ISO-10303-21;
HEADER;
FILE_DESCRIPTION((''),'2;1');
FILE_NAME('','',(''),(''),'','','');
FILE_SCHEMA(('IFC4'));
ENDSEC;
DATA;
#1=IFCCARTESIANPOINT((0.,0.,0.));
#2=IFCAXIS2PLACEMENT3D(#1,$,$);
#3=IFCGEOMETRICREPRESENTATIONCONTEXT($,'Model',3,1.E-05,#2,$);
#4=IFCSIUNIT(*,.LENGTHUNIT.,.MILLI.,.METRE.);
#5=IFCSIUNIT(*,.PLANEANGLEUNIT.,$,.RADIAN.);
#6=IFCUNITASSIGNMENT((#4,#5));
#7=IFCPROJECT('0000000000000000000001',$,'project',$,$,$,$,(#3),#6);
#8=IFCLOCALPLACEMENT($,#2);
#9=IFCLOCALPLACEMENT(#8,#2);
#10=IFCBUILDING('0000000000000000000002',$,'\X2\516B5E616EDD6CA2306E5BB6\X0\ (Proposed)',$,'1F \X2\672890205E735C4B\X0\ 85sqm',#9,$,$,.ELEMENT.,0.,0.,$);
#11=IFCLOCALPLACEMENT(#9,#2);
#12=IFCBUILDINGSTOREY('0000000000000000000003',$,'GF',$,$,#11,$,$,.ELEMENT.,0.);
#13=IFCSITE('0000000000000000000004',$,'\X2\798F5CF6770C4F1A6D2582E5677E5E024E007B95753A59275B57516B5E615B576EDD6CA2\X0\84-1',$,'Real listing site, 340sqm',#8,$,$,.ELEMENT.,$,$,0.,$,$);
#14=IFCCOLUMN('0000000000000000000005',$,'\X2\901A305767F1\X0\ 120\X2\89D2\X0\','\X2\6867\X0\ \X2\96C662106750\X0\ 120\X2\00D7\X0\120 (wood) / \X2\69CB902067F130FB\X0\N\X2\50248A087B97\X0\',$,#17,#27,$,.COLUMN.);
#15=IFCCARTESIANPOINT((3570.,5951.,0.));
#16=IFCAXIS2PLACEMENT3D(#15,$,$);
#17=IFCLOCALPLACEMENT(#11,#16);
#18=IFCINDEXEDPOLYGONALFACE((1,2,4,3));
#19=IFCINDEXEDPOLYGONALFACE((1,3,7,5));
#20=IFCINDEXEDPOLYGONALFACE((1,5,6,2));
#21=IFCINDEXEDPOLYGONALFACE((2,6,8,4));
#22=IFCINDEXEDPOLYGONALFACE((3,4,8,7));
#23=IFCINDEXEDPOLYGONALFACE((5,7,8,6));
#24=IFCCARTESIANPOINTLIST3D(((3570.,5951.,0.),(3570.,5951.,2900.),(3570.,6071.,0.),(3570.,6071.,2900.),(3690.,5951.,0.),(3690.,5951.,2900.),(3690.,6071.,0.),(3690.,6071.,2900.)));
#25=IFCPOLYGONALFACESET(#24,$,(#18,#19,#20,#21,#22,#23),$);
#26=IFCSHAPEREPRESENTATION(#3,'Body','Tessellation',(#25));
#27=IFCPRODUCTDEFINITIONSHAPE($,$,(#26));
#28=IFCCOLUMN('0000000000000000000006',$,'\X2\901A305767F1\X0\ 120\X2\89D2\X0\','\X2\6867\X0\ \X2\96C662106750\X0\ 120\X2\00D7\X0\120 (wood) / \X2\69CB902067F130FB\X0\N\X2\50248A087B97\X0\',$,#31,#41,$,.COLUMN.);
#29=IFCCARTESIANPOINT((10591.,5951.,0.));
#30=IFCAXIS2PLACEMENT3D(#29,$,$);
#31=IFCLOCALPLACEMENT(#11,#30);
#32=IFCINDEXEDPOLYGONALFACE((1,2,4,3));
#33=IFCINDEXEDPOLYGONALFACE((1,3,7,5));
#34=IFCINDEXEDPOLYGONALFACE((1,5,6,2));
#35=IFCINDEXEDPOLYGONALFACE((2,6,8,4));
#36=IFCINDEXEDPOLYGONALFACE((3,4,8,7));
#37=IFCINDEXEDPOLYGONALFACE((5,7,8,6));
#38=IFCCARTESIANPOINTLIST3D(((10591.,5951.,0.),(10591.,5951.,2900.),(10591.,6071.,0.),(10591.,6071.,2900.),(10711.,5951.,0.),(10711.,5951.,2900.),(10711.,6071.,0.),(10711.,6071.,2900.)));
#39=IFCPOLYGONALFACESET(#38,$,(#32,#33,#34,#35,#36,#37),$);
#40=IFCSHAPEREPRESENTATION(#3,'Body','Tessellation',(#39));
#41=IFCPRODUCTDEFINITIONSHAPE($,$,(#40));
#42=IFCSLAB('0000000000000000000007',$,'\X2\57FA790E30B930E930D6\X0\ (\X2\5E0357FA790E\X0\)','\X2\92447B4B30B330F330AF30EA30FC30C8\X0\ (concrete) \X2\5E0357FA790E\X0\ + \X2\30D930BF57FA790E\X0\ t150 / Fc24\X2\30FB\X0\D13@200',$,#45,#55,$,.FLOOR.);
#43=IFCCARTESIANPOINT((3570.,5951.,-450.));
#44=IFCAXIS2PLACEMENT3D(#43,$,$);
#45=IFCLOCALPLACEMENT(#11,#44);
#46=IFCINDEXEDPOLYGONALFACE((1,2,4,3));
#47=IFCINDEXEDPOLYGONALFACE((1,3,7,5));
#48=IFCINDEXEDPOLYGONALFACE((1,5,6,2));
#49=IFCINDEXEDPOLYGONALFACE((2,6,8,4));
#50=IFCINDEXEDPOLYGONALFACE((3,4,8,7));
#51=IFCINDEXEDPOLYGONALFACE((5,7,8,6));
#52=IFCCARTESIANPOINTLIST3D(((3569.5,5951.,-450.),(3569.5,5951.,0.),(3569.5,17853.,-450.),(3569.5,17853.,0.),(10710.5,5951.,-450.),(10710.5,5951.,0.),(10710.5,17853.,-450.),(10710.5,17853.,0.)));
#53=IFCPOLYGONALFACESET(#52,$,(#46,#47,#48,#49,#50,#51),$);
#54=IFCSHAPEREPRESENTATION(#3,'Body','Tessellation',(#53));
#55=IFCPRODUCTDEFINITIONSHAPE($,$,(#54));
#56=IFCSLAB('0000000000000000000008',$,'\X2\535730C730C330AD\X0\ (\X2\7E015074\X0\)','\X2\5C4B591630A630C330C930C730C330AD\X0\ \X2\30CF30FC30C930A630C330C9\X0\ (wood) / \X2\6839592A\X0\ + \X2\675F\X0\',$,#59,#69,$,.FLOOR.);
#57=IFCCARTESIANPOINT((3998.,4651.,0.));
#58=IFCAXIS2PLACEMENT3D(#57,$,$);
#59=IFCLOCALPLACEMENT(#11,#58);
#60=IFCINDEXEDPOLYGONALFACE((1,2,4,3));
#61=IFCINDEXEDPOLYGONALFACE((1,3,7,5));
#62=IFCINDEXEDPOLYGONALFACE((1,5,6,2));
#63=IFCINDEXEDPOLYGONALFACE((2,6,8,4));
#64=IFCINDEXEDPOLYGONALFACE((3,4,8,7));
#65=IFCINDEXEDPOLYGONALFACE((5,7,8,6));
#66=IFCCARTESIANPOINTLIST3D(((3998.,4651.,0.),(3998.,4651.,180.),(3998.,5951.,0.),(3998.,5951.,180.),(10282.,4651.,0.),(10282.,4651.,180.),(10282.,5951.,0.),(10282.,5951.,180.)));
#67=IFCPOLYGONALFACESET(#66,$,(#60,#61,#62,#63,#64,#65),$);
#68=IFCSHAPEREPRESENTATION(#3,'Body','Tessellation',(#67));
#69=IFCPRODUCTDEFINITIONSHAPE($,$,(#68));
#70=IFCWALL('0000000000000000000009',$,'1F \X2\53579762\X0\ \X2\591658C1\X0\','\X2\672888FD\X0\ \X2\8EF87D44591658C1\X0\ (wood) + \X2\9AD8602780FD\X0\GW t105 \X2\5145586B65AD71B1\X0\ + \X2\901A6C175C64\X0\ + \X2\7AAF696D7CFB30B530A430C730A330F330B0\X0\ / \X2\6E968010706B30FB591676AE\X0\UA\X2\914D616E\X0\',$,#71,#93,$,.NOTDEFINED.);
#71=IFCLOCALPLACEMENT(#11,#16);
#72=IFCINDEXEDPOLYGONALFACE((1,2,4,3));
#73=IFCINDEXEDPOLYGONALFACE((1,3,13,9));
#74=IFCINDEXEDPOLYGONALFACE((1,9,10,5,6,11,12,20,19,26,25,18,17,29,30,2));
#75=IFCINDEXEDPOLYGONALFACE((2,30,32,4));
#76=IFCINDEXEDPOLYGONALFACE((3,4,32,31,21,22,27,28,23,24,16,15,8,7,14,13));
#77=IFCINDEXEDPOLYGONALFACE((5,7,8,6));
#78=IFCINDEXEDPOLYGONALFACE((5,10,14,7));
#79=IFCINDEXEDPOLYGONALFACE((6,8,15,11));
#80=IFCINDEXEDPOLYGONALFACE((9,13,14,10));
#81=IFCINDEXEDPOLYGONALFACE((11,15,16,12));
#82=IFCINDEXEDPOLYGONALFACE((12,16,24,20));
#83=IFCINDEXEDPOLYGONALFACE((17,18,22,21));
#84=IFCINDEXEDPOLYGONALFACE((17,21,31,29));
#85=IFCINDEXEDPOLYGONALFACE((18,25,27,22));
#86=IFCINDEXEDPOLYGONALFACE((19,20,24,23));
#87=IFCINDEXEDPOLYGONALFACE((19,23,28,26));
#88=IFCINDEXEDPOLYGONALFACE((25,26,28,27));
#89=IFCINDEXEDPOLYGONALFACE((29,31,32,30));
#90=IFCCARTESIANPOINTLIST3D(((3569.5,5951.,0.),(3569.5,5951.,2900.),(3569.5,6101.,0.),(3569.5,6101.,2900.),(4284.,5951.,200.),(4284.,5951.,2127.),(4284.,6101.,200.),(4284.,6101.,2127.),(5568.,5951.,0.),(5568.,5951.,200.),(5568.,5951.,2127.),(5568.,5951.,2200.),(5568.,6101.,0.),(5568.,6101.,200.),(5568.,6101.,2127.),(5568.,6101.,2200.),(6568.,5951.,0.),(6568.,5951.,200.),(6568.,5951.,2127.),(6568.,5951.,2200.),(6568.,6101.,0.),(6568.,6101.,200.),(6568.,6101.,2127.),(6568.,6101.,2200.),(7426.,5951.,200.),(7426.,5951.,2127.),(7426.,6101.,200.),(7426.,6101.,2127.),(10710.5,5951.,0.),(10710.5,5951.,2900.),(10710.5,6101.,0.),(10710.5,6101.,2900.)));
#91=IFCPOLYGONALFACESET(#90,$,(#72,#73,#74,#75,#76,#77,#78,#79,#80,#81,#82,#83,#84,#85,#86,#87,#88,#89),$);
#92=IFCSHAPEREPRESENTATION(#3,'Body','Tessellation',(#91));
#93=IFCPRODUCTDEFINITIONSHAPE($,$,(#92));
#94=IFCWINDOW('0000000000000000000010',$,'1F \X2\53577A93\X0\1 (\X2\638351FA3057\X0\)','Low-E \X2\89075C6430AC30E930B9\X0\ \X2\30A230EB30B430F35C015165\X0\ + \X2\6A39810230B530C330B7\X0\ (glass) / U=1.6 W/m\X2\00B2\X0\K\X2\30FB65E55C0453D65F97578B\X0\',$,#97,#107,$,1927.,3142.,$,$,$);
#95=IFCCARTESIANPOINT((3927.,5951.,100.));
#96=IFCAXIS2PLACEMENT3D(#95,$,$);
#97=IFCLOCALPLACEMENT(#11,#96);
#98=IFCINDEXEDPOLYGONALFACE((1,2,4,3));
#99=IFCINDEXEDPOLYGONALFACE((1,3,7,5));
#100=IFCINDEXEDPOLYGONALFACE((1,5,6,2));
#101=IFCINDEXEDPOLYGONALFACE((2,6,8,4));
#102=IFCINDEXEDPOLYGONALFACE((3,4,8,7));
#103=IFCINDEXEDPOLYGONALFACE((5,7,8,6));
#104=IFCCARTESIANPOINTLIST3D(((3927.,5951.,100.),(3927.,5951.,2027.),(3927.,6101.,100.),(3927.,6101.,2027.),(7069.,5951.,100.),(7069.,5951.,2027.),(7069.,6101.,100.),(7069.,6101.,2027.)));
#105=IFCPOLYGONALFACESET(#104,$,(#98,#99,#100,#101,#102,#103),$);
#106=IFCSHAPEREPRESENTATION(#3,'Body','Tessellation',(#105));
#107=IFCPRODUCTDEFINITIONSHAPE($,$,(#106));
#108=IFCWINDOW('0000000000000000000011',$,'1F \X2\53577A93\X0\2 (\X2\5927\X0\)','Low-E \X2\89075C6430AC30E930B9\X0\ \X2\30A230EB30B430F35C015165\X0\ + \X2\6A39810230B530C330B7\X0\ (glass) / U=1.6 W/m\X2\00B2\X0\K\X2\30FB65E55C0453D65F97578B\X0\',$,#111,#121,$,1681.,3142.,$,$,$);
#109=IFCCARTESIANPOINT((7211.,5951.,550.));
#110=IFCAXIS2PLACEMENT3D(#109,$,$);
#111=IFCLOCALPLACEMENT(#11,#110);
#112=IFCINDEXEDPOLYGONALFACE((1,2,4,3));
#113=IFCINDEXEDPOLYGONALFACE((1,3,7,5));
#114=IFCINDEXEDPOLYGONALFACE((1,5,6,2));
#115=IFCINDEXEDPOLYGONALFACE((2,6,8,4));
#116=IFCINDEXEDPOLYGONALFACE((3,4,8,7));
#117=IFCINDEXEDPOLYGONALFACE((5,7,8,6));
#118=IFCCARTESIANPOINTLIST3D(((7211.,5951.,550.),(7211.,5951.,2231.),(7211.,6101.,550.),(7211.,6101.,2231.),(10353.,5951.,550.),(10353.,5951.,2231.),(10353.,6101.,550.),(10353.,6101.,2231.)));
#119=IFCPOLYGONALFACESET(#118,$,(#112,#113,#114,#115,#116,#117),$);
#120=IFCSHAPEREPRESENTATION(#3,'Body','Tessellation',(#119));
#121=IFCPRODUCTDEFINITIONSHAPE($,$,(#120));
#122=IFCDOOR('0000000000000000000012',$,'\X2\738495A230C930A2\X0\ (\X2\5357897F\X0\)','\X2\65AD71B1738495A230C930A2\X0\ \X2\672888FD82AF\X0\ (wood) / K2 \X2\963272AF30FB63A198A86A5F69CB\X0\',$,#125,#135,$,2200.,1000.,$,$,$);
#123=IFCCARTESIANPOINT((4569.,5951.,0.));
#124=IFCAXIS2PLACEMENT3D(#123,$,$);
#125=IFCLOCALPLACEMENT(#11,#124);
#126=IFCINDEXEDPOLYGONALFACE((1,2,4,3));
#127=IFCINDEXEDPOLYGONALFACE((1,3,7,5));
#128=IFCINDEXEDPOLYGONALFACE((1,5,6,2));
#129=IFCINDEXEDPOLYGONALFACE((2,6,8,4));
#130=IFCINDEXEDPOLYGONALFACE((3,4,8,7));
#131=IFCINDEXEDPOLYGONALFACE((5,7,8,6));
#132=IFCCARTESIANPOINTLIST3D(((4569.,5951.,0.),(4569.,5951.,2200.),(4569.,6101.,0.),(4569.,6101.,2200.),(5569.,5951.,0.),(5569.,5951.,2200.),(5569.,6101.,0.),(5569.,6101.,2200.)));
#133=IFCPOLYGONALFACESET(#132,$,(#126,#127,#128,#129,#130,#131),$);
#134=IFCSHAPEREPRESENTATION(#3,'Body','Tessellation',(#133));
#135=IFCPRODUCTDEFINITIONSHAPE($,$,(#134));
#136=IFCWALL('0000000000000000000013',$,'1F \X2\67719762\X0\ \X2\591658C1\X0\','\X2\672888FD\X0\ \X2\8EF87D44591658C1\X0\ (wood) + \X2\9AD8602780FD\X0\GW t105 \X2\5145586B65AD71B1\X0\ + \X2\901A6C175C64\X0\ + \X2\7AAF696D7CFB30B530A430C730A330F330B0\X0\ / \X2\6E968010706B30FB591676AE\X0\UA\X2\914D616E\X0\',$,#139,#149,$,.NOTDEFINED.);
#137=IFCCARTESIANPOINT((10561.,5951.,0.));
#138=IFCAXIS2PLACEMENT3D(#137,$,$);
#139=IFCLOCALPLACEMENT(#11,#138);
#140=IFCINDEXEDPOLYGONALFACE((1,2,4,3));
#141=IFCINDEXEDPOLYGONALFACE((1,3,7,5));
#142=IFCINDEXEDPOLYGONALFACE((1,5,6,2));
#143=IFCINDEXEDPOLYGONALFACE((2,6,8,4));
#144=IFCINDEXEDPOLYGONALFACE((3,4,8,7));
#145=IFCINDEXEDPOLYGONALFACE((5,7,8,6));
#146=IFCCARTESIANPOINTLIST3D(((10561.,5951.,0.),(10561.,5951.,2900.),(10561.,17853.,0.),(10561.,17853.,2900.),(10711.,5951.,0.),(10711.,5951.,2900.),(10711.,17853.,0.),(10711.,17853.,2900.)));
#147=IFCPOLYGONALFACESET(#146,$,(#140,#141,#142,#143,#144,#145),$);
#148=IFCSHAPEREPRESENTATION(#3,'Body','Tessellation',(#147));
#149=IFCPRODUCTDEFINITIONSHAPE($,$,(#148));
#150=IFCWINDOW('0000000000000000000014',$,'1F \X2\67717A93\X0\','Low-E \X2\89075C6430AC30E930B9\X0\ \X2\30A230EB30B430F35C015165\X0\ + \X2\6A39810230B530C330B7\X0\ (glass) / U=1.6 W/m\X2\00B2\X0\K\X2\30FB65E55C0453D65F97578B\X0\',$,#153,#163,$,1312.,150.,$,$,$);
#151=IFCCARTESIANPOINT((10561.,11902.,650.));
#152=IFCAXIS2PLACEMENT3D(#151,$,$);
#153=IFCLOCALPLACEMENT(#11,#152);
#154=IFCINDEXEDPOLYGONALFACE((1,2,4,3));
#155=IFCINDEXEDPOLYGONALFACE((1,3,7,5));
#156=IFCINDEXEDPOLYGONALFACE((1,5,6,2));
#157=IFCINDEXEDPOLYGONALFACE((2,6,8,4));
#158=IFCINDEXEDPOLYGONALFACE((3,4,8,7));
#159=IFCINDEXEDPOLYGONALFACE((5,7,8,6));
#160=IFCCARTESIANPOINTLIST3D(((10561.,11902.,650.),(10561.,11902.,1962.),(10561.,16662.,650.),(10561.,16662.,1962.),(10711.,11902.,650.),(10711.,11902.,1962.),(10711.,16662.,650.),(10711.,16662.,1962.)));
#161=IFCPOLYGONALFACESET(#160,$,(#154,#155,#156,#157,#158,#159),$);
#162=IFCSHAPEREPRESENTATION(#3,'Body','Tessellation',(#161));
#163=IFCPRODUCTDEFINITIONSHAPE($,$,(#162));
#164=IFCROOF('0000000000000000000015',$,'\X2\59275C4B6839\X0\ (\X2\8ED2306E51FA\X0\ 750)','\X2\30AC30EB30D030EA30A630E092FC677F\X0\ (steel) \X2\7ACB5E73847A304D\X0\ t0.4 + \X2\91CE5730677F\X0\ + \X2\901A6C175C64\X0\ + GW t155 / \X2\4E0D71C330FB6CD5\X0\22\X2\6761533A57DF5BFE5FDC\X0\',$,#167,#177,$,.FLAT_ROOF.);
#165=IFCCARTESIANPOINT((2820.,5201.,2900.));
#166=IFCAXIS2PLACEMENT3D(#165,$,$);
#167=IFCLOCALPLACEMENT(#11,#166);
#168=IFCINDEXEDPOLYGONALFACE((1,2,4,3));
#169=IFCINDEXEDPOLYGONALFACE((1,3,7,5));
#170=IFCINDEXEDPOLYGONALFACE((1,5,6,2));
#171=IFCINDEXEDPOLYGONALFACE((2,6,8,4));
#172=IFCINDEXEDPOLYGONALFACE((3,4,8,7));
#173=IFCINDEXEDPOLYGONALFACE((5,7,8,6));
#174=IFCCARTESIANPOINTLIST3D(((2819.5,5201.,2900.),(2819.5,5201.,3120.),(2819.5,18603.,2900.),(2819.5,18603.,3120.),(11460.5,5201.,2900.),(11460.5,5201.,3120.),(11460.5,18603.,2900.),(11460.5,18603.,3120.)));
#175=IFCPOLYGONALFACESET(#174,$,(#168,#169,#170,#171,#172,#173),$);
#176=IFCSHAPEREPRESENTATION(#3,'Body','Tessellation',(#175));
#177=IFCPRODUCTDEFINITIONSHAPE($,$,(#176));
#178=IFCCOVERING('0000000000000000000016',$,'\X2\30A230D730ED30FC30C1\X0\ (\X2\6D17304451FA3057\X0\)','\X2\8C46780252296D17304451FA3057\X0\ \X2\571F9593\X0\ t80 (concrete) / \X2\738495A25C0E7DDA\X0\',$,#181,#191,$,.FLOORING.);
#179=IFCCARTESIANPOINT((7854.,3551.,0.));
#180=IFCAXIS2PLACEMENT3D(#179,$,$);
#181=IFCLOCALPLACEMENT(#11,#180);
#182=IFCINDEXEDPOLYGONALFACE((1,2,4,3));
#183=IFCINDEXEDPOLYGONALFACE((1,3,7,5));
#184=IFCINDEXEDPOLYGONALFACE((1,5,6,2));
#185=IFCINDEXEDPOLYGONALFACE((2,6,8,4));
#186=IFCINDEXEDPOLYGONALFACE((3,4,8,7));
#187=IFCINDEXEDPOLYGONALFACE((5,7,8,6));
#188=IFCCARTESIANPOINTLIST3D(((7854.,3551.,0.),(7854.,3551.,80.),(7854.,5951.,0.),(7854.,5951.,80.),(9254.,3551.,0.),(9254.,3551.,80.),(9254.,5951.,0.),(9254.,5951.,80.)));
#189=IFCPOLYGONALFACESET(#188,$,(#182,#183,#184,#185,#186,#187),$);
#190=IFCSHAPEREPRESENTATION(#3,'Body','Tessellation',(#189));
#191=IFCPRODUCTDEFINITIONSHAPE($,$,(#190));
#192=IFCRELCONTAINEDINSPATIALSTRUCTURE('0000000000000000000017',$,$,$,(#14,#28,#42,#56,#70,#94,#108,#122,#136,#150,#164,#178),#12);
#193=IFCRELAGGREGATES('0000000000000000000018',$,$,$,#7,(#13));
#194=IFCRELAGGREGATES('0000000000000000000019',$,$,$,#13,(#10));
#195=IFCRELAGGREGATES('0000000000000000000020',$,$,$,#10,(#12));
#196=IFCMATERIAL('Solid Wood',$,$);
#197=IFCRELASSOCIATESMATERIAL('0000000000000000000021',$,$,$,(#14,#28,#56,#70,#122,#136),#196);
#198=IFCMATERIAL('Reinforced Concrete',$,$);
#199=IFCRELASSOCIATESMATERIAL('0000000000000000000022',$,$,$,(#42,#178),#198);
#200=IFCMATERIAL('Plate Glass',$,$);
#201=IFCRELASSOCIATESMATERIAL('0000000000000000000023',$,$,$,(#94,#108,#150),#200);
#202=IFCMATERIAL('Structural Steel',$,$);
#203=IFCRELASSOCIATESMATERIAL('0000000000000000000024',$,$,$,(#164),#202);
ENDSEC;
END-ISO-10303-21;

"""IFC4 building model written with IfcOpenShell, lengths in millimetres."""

from ifc_helpers import new_model, si_unit, frame, frame_2d, origin, place, context, project, spatial, rectangle, extrude, material, element, fill, save


model = new_model("IFC4")

# Units and contexts
model_context = context("Model", 3, precision=1e-05, world=origin())
ifc_project = project(units=[si_unit("LENGTHUNIT", "METRE", prefix="MILLI"), si_unit("PLANEANGLEUNIT", "RADIAN")], contexts=[model_context])

# Site, building, storey
site_placement = place(None, origin())
site = spatial("IfcSite", under=ifc_project, at=site_placement, Name="福島県会津若松市一箕町大字八幡字滝沢84-1", ObjectType="Real listing site, 340sqm", CompositionType="ELEMENT", RefElevation=0.0)
building_placement = place(site_placement, origin())
building = spatial("IfcBuilding", under=site, at=building_placement, Name="八幡滝沢の家 (Proposed)", ObjectType="1F 木造平屋 85sqm", CompositionType="ELEMENT", ElevationOfRefHeight=0.0, ElevationOfTerrain=0.0)
storey_placement = place(building_placement, origin())
storey = spatial("IfcBuildingStorey", under=building, at=storey_placement, Name="GF", CompositionType="ELEMENT", Elevation=0.0)

# Columns
ifc_material_1 = material(Name="Solid Wood")
column_1_placement = place(storey_placement, frame((3570.0, 5951.0, 0.0)))
element("IfcColumn", 1, at=column_1_placement, inside=storey, material=ifc_material_1, Name="通し柱 120角", Description="桧 集成材 120×120 (wood) / 構造柱・N値計算", PredefinedType="COLUMN", context=model_context, shape_type="SweptSolid", body=[
    extrude(rectangle(XDim=120.0, YDim=120.0, at=frame_2d((60.0, 60.0))), frame((3570.0, 5951.0, 0.0)), (0.0, 0.0, 1.0), 2900.0),
])
column_2_placement = place(storey_placement, frame((10591.0, 5951.0, 0.0)))
element("IfcColumn", 2, at=column_2_placement, inside=storey, material=ifc_material_1, Name="通し柱 120角", Description="桧 集成材 120×120 (wood) / 構造柱・N値計算", PredefinedType="COLUMN", context=model_context, shape_type="SweptSolid", body=[
    extrude(rectangle(XDim=120.0, YDim=120.0, at=frame_2d((60.0, 60.0))), frame((10591.0, 5951.0, 0.0)), (0.0, 0.0, 1.0), 2900.0),
])

# Slabs
ifc_material_2 = material(Name="Reinforced Concrete")
slab_1_placement = place(storey_placement, frame((3570.0, 5951.0, -450.0)))
element("IfcSlab", 3, at=slab_1_placement, inside=storey, material=ifc_material_2, Name="基礎スラブ (布基礎)", Description="鉄筋コンクリート (concrete) 布基礎 + ベタ基礎 t150 / Fc24・D13@200", PredefinedType="FLOOR", context=model_context, shape_type="SweptSolid", body=[
    extrude(rectangle(XDim=7141.0, YDim=11902.0, at=frame_2d((3570.0, 5951.0))), frame((3570.0, 5951.0, -450.0)), (0.0, 0.0, 1.0), 450.0),
])
slab_2_placement = place(storey_placement, frame((3998.0, 4651.0, 0.0)))
element("IfcSlab", 4, at=slab_2_placement, inside=storey, material=ifc_material_1, Name="南デッキ (縁側)", Description="屋外ウッドデッキ ハードウッド (wood) / 根太 + 束", PredefinedType="FLOOR", context=model_context, shape_type="SweptSolid", body=[
    extrude(rectangle(XDim=6284.0, YDim=1300.0, at=frame_2d((3142.0, 650.0))), frame((3998.0, 4651.0, 0.0)), (0.0, 0.0, 1.0), 180.0),
])

# Wall, openings, windows, door
wall_1_placement = place(storey_placement, frame((3570.0, 5951.0, 0.0)))
wall_1 = element("IfcWall", 5, at=wall_1_placement, inside=storey, material=ifc_material_1, Name="1F 南面 外壁", Description="木製 軸組外壁 (wood) + 高性能GW t105 充填断熱 + 通気層 + 窯業系サイディング / 準耐火・外皮UA配慮", PredefinedType="NOTDEFINED", context=model_context, shape_type="SweptSolid", body=[
    extrude(rectangle(XDim=7141.0, YDim=150.0, at=frame_2d((3570.0, 75.0))), frame((3570.0, 5951.0, 0.0)), (0.0, 0.0, 1.0), 2900.0),
])
opening_1_placement = place(storey_placement, frame((3927.0, 5951.0, 100.0)))
opening_1 = element("IfcOpeningElement", 6, at=opening_1_placement, cuts=wall_1, PredefinedType="NOTDEFINED", context=model_context, shape_type="SweptSolid", body=[
    extrude(rectangle(XDim=3142.0, YDim=150.0, at=frame_2d((1571.0, 75.0))), frame((3927.0, 5951.0, 100.0)), (0.0, 0.0, 1.0), 1927.0),
])
opening_2_placement = place(storey_placement, frame((7211.0, 5951.0, 550.0)))
opening_2 = element("IfcOpeningElement", 7, at=opening_2_placement, cuts=wall_1, PredefinedType="NOTDEFINED", context=model_context, shape_type="SweptSolid", body=[
    extrude(rectangle(XDim=3142.0, YDim=150.0, at=frame_2d((1571.0, 75.0))), frame((7211.0, 5951.0, 550.0)), (0.0, 0.0, 1.0), 1681.0),
])
opening_3_placement = place(storey_placement, frame((4569.0, 5951.0, 0.0)))
opening_3 = element("IfcOpeningElement", 8, at=opening_3_placement, cuts=wall_1, PredefinedType="NOTDEFINED", context=model_context, shape_type="SweptSolid", body=[
    extrude(rectangle(XDim=1000.0, YDim=150.0, at=frame_2d((500.0, 75.0))), frame((4569.0, 5951.0, 0.0)), (0.0, 0.0, 1.0), 2200.0),
])
ifc_material_3 = material(Name="Plate Glass")
window_1_placement = place(storey_placement, frame((3927.0, 5951.0, 100.0)))
window_1 = element("IfcWindow", 9, at=window_1_placement, inside=storey, material=ifc_material_3, Name="1F 南窓1 (掃出し)", Description="Low-E 複層ガラス アルゴン封入 + 樹脂サッシ (glass) / U=1.6 W/m²K・日射取得型", OverallHeight=1927.0, OverallWidth=3142.0, context=model_context, shape_type="SweptSolid", body=[
    extrude(rectangle(XDim=3142.0, YDim=150.0, at=frame_2d((1571.0, 75.0))), frame((3927.0, 5951.0, 100.0)), (0.0, 0.0, 1.0), 1927.0),
])
fill(opening_1, window_1)
window_2_placement = place(storey_placement, frame((7211.0, 5951.0, 550.0)))
window_2 = element("IfcWindow", 10, at=window_2_placement, inside=storey, material=ifc_material_3, Name="1F 南窓2 (大)", Description="Low-E 複層ガラス アルゴン封入 + 樹脂サッシ (glass) / U=1.6 W/m²K・日射取得型", OverallHeight=1681.0, OverallWidth=3142.0, context=model_context, shape_type="SweptSolid", body=[
    extrude(rectangle(XDim=3142.0, YDim=150.0, at=frame_2d((1571.0, 75.0))), frame((7211.0, 5951.0, 550.0)), (0.0, 0.0, 1.0), 1681.0),
])
fill(opening_2, window_2)
door_placement = place(storey_placement, frame((4569.0, 5951.0, 0.0)))
door = element("IfcDoor", 11, at=door_placement, inside=storey, material=ifc_material_1, Name="玄関ドア (南西)", Description="断熱玄関ドア 木製芯 (wood) / K2 防犯・採風機構", OverallHeight=2200.0, OverallWidth=1000.0, context=model_context, shape_type="SweptSolid", body=[
    extrude(rectangle(XDim=1000.0, YDim=150.0, at=frame_2d((500.0, 75.0))), frame((4569.0, 5951.0, 0.0)), (0.0, 0.0, 1.0), 2200.0),
])
fill(opening_3, door)

# Wall, opening, window
wall_2_placement = place(storey_placement, frame((10561.0, 5951.0, 0.0)))
wall_2 = element("IfcWall", 12, at=wall_2_placement, inside=storey, material=ifc_material_1, Name="1F 東面 外壁", Description="木製 軸組外壁 (wood) + 高性能GW t105 充填断熱 + 通気層 + 窯業系サイディング / 準耐火・外皮UA配慮", PredefinedType="NOTDEFINED", context=model_context, shape_type="SweptSolid", body=[
    extrude(rectangle(XDim=150.0, YDim=11902.0, at=frame_2d((75.0, 5951.0))), frame((10561.0, 5951.0, 0.0)), (0.0, 0.0, 1.0), 2900.0),
])
opening_4_placement = place(storey_placement, frame((10561.0, 11902.0, 650.0)))
opening_4 = element("IfcOpeningElement", 13, at=opening_4_placement, cuts=wall_2, PredefinedType="NOTDEFINED", context=model_context, shape_type="SweptSolid", body=[
    extrude(rectangle(XDim=150.0, YDim=4760.0, at=frame_2d((75.0, 2380.0))), frame((10561.0, 11902.0, 650.0)), (0.0, 0.0, 1.0), 1312.0),
])
window_3_placement = place(storey_placement, frame((10561.0, 11902.0, 650.0)))
window_3 = element("IfcWindow", 14, at=window_3_placement, inside=storey, material=ifc_material_3, Name="1F 東窓", Description="Low-E 複層ガラス アルゴン封入 + 樹脂サッシ (glass) / U=1.6 W/m²K・日射取得型", OverallHeight=1312.0, OverallWidth=150.0, context=model_context, shape_type="SweptSolid", body=[
    extrude(rectangle(XDim=150.0, YDim=4760.0, at=frame_2d((75.0, 2380.0))), frame((10561.0, 11902.0, 650.0)), (0.0, 0.0, 1.0), 1312.0),
])
fill(opening_4, window_3)

# Roof
ifc_material_4 = material(Name="Structural Steel")
roof_placement = place(storey_placement, frame((2820.0, 5201.0, 2900.0)))
element("IfcRoof", 15, at=roof_placement, inside=storey, material=ifc_material_4, Name="大屋根 (軒の出 750)", Description="ガルバリウム鋼板 (steel) 立平葺き t0.4 + 野地板 + 通気層 + GW t155 / 不燃・法22条区域対応", PredefinedType="FLAT_ROOF", context=model_context, shape_type="SweptSolid", body=[
    extrude(rectangle(XDim=8641.0, YDim=13402.0, at=frame_2d((4320.0, 6701.0))), frame((2820.0, 5201.0, 2900.0)), (0.0, 0.0, 1.0), 220.0),
])

# Covering
covering_1_placement = place(storey_placement, frame((7854.0, 3551.0, 0.0)))
element("IfcCovering", 16, at=covering_1_placement, inside=storey, material=ifc_material_2, Name="アプローチ (洗い出し)", Description="豆砂利洗い出し 土間 t80 (concrete) / 玄関導線", PredefinedType="FLOORING", context=model_context, shape_type="SweptSolid", body=[
    extrude(rectangle(XDim=1400.0, YDim=2400.0, at=frame_2d((700.0, 1200.0))), frame((7854.0, 3551.0, 0.0)), (0.0, 0.0, 1.0), 80.0),
])

save(model, "model.ifc")
